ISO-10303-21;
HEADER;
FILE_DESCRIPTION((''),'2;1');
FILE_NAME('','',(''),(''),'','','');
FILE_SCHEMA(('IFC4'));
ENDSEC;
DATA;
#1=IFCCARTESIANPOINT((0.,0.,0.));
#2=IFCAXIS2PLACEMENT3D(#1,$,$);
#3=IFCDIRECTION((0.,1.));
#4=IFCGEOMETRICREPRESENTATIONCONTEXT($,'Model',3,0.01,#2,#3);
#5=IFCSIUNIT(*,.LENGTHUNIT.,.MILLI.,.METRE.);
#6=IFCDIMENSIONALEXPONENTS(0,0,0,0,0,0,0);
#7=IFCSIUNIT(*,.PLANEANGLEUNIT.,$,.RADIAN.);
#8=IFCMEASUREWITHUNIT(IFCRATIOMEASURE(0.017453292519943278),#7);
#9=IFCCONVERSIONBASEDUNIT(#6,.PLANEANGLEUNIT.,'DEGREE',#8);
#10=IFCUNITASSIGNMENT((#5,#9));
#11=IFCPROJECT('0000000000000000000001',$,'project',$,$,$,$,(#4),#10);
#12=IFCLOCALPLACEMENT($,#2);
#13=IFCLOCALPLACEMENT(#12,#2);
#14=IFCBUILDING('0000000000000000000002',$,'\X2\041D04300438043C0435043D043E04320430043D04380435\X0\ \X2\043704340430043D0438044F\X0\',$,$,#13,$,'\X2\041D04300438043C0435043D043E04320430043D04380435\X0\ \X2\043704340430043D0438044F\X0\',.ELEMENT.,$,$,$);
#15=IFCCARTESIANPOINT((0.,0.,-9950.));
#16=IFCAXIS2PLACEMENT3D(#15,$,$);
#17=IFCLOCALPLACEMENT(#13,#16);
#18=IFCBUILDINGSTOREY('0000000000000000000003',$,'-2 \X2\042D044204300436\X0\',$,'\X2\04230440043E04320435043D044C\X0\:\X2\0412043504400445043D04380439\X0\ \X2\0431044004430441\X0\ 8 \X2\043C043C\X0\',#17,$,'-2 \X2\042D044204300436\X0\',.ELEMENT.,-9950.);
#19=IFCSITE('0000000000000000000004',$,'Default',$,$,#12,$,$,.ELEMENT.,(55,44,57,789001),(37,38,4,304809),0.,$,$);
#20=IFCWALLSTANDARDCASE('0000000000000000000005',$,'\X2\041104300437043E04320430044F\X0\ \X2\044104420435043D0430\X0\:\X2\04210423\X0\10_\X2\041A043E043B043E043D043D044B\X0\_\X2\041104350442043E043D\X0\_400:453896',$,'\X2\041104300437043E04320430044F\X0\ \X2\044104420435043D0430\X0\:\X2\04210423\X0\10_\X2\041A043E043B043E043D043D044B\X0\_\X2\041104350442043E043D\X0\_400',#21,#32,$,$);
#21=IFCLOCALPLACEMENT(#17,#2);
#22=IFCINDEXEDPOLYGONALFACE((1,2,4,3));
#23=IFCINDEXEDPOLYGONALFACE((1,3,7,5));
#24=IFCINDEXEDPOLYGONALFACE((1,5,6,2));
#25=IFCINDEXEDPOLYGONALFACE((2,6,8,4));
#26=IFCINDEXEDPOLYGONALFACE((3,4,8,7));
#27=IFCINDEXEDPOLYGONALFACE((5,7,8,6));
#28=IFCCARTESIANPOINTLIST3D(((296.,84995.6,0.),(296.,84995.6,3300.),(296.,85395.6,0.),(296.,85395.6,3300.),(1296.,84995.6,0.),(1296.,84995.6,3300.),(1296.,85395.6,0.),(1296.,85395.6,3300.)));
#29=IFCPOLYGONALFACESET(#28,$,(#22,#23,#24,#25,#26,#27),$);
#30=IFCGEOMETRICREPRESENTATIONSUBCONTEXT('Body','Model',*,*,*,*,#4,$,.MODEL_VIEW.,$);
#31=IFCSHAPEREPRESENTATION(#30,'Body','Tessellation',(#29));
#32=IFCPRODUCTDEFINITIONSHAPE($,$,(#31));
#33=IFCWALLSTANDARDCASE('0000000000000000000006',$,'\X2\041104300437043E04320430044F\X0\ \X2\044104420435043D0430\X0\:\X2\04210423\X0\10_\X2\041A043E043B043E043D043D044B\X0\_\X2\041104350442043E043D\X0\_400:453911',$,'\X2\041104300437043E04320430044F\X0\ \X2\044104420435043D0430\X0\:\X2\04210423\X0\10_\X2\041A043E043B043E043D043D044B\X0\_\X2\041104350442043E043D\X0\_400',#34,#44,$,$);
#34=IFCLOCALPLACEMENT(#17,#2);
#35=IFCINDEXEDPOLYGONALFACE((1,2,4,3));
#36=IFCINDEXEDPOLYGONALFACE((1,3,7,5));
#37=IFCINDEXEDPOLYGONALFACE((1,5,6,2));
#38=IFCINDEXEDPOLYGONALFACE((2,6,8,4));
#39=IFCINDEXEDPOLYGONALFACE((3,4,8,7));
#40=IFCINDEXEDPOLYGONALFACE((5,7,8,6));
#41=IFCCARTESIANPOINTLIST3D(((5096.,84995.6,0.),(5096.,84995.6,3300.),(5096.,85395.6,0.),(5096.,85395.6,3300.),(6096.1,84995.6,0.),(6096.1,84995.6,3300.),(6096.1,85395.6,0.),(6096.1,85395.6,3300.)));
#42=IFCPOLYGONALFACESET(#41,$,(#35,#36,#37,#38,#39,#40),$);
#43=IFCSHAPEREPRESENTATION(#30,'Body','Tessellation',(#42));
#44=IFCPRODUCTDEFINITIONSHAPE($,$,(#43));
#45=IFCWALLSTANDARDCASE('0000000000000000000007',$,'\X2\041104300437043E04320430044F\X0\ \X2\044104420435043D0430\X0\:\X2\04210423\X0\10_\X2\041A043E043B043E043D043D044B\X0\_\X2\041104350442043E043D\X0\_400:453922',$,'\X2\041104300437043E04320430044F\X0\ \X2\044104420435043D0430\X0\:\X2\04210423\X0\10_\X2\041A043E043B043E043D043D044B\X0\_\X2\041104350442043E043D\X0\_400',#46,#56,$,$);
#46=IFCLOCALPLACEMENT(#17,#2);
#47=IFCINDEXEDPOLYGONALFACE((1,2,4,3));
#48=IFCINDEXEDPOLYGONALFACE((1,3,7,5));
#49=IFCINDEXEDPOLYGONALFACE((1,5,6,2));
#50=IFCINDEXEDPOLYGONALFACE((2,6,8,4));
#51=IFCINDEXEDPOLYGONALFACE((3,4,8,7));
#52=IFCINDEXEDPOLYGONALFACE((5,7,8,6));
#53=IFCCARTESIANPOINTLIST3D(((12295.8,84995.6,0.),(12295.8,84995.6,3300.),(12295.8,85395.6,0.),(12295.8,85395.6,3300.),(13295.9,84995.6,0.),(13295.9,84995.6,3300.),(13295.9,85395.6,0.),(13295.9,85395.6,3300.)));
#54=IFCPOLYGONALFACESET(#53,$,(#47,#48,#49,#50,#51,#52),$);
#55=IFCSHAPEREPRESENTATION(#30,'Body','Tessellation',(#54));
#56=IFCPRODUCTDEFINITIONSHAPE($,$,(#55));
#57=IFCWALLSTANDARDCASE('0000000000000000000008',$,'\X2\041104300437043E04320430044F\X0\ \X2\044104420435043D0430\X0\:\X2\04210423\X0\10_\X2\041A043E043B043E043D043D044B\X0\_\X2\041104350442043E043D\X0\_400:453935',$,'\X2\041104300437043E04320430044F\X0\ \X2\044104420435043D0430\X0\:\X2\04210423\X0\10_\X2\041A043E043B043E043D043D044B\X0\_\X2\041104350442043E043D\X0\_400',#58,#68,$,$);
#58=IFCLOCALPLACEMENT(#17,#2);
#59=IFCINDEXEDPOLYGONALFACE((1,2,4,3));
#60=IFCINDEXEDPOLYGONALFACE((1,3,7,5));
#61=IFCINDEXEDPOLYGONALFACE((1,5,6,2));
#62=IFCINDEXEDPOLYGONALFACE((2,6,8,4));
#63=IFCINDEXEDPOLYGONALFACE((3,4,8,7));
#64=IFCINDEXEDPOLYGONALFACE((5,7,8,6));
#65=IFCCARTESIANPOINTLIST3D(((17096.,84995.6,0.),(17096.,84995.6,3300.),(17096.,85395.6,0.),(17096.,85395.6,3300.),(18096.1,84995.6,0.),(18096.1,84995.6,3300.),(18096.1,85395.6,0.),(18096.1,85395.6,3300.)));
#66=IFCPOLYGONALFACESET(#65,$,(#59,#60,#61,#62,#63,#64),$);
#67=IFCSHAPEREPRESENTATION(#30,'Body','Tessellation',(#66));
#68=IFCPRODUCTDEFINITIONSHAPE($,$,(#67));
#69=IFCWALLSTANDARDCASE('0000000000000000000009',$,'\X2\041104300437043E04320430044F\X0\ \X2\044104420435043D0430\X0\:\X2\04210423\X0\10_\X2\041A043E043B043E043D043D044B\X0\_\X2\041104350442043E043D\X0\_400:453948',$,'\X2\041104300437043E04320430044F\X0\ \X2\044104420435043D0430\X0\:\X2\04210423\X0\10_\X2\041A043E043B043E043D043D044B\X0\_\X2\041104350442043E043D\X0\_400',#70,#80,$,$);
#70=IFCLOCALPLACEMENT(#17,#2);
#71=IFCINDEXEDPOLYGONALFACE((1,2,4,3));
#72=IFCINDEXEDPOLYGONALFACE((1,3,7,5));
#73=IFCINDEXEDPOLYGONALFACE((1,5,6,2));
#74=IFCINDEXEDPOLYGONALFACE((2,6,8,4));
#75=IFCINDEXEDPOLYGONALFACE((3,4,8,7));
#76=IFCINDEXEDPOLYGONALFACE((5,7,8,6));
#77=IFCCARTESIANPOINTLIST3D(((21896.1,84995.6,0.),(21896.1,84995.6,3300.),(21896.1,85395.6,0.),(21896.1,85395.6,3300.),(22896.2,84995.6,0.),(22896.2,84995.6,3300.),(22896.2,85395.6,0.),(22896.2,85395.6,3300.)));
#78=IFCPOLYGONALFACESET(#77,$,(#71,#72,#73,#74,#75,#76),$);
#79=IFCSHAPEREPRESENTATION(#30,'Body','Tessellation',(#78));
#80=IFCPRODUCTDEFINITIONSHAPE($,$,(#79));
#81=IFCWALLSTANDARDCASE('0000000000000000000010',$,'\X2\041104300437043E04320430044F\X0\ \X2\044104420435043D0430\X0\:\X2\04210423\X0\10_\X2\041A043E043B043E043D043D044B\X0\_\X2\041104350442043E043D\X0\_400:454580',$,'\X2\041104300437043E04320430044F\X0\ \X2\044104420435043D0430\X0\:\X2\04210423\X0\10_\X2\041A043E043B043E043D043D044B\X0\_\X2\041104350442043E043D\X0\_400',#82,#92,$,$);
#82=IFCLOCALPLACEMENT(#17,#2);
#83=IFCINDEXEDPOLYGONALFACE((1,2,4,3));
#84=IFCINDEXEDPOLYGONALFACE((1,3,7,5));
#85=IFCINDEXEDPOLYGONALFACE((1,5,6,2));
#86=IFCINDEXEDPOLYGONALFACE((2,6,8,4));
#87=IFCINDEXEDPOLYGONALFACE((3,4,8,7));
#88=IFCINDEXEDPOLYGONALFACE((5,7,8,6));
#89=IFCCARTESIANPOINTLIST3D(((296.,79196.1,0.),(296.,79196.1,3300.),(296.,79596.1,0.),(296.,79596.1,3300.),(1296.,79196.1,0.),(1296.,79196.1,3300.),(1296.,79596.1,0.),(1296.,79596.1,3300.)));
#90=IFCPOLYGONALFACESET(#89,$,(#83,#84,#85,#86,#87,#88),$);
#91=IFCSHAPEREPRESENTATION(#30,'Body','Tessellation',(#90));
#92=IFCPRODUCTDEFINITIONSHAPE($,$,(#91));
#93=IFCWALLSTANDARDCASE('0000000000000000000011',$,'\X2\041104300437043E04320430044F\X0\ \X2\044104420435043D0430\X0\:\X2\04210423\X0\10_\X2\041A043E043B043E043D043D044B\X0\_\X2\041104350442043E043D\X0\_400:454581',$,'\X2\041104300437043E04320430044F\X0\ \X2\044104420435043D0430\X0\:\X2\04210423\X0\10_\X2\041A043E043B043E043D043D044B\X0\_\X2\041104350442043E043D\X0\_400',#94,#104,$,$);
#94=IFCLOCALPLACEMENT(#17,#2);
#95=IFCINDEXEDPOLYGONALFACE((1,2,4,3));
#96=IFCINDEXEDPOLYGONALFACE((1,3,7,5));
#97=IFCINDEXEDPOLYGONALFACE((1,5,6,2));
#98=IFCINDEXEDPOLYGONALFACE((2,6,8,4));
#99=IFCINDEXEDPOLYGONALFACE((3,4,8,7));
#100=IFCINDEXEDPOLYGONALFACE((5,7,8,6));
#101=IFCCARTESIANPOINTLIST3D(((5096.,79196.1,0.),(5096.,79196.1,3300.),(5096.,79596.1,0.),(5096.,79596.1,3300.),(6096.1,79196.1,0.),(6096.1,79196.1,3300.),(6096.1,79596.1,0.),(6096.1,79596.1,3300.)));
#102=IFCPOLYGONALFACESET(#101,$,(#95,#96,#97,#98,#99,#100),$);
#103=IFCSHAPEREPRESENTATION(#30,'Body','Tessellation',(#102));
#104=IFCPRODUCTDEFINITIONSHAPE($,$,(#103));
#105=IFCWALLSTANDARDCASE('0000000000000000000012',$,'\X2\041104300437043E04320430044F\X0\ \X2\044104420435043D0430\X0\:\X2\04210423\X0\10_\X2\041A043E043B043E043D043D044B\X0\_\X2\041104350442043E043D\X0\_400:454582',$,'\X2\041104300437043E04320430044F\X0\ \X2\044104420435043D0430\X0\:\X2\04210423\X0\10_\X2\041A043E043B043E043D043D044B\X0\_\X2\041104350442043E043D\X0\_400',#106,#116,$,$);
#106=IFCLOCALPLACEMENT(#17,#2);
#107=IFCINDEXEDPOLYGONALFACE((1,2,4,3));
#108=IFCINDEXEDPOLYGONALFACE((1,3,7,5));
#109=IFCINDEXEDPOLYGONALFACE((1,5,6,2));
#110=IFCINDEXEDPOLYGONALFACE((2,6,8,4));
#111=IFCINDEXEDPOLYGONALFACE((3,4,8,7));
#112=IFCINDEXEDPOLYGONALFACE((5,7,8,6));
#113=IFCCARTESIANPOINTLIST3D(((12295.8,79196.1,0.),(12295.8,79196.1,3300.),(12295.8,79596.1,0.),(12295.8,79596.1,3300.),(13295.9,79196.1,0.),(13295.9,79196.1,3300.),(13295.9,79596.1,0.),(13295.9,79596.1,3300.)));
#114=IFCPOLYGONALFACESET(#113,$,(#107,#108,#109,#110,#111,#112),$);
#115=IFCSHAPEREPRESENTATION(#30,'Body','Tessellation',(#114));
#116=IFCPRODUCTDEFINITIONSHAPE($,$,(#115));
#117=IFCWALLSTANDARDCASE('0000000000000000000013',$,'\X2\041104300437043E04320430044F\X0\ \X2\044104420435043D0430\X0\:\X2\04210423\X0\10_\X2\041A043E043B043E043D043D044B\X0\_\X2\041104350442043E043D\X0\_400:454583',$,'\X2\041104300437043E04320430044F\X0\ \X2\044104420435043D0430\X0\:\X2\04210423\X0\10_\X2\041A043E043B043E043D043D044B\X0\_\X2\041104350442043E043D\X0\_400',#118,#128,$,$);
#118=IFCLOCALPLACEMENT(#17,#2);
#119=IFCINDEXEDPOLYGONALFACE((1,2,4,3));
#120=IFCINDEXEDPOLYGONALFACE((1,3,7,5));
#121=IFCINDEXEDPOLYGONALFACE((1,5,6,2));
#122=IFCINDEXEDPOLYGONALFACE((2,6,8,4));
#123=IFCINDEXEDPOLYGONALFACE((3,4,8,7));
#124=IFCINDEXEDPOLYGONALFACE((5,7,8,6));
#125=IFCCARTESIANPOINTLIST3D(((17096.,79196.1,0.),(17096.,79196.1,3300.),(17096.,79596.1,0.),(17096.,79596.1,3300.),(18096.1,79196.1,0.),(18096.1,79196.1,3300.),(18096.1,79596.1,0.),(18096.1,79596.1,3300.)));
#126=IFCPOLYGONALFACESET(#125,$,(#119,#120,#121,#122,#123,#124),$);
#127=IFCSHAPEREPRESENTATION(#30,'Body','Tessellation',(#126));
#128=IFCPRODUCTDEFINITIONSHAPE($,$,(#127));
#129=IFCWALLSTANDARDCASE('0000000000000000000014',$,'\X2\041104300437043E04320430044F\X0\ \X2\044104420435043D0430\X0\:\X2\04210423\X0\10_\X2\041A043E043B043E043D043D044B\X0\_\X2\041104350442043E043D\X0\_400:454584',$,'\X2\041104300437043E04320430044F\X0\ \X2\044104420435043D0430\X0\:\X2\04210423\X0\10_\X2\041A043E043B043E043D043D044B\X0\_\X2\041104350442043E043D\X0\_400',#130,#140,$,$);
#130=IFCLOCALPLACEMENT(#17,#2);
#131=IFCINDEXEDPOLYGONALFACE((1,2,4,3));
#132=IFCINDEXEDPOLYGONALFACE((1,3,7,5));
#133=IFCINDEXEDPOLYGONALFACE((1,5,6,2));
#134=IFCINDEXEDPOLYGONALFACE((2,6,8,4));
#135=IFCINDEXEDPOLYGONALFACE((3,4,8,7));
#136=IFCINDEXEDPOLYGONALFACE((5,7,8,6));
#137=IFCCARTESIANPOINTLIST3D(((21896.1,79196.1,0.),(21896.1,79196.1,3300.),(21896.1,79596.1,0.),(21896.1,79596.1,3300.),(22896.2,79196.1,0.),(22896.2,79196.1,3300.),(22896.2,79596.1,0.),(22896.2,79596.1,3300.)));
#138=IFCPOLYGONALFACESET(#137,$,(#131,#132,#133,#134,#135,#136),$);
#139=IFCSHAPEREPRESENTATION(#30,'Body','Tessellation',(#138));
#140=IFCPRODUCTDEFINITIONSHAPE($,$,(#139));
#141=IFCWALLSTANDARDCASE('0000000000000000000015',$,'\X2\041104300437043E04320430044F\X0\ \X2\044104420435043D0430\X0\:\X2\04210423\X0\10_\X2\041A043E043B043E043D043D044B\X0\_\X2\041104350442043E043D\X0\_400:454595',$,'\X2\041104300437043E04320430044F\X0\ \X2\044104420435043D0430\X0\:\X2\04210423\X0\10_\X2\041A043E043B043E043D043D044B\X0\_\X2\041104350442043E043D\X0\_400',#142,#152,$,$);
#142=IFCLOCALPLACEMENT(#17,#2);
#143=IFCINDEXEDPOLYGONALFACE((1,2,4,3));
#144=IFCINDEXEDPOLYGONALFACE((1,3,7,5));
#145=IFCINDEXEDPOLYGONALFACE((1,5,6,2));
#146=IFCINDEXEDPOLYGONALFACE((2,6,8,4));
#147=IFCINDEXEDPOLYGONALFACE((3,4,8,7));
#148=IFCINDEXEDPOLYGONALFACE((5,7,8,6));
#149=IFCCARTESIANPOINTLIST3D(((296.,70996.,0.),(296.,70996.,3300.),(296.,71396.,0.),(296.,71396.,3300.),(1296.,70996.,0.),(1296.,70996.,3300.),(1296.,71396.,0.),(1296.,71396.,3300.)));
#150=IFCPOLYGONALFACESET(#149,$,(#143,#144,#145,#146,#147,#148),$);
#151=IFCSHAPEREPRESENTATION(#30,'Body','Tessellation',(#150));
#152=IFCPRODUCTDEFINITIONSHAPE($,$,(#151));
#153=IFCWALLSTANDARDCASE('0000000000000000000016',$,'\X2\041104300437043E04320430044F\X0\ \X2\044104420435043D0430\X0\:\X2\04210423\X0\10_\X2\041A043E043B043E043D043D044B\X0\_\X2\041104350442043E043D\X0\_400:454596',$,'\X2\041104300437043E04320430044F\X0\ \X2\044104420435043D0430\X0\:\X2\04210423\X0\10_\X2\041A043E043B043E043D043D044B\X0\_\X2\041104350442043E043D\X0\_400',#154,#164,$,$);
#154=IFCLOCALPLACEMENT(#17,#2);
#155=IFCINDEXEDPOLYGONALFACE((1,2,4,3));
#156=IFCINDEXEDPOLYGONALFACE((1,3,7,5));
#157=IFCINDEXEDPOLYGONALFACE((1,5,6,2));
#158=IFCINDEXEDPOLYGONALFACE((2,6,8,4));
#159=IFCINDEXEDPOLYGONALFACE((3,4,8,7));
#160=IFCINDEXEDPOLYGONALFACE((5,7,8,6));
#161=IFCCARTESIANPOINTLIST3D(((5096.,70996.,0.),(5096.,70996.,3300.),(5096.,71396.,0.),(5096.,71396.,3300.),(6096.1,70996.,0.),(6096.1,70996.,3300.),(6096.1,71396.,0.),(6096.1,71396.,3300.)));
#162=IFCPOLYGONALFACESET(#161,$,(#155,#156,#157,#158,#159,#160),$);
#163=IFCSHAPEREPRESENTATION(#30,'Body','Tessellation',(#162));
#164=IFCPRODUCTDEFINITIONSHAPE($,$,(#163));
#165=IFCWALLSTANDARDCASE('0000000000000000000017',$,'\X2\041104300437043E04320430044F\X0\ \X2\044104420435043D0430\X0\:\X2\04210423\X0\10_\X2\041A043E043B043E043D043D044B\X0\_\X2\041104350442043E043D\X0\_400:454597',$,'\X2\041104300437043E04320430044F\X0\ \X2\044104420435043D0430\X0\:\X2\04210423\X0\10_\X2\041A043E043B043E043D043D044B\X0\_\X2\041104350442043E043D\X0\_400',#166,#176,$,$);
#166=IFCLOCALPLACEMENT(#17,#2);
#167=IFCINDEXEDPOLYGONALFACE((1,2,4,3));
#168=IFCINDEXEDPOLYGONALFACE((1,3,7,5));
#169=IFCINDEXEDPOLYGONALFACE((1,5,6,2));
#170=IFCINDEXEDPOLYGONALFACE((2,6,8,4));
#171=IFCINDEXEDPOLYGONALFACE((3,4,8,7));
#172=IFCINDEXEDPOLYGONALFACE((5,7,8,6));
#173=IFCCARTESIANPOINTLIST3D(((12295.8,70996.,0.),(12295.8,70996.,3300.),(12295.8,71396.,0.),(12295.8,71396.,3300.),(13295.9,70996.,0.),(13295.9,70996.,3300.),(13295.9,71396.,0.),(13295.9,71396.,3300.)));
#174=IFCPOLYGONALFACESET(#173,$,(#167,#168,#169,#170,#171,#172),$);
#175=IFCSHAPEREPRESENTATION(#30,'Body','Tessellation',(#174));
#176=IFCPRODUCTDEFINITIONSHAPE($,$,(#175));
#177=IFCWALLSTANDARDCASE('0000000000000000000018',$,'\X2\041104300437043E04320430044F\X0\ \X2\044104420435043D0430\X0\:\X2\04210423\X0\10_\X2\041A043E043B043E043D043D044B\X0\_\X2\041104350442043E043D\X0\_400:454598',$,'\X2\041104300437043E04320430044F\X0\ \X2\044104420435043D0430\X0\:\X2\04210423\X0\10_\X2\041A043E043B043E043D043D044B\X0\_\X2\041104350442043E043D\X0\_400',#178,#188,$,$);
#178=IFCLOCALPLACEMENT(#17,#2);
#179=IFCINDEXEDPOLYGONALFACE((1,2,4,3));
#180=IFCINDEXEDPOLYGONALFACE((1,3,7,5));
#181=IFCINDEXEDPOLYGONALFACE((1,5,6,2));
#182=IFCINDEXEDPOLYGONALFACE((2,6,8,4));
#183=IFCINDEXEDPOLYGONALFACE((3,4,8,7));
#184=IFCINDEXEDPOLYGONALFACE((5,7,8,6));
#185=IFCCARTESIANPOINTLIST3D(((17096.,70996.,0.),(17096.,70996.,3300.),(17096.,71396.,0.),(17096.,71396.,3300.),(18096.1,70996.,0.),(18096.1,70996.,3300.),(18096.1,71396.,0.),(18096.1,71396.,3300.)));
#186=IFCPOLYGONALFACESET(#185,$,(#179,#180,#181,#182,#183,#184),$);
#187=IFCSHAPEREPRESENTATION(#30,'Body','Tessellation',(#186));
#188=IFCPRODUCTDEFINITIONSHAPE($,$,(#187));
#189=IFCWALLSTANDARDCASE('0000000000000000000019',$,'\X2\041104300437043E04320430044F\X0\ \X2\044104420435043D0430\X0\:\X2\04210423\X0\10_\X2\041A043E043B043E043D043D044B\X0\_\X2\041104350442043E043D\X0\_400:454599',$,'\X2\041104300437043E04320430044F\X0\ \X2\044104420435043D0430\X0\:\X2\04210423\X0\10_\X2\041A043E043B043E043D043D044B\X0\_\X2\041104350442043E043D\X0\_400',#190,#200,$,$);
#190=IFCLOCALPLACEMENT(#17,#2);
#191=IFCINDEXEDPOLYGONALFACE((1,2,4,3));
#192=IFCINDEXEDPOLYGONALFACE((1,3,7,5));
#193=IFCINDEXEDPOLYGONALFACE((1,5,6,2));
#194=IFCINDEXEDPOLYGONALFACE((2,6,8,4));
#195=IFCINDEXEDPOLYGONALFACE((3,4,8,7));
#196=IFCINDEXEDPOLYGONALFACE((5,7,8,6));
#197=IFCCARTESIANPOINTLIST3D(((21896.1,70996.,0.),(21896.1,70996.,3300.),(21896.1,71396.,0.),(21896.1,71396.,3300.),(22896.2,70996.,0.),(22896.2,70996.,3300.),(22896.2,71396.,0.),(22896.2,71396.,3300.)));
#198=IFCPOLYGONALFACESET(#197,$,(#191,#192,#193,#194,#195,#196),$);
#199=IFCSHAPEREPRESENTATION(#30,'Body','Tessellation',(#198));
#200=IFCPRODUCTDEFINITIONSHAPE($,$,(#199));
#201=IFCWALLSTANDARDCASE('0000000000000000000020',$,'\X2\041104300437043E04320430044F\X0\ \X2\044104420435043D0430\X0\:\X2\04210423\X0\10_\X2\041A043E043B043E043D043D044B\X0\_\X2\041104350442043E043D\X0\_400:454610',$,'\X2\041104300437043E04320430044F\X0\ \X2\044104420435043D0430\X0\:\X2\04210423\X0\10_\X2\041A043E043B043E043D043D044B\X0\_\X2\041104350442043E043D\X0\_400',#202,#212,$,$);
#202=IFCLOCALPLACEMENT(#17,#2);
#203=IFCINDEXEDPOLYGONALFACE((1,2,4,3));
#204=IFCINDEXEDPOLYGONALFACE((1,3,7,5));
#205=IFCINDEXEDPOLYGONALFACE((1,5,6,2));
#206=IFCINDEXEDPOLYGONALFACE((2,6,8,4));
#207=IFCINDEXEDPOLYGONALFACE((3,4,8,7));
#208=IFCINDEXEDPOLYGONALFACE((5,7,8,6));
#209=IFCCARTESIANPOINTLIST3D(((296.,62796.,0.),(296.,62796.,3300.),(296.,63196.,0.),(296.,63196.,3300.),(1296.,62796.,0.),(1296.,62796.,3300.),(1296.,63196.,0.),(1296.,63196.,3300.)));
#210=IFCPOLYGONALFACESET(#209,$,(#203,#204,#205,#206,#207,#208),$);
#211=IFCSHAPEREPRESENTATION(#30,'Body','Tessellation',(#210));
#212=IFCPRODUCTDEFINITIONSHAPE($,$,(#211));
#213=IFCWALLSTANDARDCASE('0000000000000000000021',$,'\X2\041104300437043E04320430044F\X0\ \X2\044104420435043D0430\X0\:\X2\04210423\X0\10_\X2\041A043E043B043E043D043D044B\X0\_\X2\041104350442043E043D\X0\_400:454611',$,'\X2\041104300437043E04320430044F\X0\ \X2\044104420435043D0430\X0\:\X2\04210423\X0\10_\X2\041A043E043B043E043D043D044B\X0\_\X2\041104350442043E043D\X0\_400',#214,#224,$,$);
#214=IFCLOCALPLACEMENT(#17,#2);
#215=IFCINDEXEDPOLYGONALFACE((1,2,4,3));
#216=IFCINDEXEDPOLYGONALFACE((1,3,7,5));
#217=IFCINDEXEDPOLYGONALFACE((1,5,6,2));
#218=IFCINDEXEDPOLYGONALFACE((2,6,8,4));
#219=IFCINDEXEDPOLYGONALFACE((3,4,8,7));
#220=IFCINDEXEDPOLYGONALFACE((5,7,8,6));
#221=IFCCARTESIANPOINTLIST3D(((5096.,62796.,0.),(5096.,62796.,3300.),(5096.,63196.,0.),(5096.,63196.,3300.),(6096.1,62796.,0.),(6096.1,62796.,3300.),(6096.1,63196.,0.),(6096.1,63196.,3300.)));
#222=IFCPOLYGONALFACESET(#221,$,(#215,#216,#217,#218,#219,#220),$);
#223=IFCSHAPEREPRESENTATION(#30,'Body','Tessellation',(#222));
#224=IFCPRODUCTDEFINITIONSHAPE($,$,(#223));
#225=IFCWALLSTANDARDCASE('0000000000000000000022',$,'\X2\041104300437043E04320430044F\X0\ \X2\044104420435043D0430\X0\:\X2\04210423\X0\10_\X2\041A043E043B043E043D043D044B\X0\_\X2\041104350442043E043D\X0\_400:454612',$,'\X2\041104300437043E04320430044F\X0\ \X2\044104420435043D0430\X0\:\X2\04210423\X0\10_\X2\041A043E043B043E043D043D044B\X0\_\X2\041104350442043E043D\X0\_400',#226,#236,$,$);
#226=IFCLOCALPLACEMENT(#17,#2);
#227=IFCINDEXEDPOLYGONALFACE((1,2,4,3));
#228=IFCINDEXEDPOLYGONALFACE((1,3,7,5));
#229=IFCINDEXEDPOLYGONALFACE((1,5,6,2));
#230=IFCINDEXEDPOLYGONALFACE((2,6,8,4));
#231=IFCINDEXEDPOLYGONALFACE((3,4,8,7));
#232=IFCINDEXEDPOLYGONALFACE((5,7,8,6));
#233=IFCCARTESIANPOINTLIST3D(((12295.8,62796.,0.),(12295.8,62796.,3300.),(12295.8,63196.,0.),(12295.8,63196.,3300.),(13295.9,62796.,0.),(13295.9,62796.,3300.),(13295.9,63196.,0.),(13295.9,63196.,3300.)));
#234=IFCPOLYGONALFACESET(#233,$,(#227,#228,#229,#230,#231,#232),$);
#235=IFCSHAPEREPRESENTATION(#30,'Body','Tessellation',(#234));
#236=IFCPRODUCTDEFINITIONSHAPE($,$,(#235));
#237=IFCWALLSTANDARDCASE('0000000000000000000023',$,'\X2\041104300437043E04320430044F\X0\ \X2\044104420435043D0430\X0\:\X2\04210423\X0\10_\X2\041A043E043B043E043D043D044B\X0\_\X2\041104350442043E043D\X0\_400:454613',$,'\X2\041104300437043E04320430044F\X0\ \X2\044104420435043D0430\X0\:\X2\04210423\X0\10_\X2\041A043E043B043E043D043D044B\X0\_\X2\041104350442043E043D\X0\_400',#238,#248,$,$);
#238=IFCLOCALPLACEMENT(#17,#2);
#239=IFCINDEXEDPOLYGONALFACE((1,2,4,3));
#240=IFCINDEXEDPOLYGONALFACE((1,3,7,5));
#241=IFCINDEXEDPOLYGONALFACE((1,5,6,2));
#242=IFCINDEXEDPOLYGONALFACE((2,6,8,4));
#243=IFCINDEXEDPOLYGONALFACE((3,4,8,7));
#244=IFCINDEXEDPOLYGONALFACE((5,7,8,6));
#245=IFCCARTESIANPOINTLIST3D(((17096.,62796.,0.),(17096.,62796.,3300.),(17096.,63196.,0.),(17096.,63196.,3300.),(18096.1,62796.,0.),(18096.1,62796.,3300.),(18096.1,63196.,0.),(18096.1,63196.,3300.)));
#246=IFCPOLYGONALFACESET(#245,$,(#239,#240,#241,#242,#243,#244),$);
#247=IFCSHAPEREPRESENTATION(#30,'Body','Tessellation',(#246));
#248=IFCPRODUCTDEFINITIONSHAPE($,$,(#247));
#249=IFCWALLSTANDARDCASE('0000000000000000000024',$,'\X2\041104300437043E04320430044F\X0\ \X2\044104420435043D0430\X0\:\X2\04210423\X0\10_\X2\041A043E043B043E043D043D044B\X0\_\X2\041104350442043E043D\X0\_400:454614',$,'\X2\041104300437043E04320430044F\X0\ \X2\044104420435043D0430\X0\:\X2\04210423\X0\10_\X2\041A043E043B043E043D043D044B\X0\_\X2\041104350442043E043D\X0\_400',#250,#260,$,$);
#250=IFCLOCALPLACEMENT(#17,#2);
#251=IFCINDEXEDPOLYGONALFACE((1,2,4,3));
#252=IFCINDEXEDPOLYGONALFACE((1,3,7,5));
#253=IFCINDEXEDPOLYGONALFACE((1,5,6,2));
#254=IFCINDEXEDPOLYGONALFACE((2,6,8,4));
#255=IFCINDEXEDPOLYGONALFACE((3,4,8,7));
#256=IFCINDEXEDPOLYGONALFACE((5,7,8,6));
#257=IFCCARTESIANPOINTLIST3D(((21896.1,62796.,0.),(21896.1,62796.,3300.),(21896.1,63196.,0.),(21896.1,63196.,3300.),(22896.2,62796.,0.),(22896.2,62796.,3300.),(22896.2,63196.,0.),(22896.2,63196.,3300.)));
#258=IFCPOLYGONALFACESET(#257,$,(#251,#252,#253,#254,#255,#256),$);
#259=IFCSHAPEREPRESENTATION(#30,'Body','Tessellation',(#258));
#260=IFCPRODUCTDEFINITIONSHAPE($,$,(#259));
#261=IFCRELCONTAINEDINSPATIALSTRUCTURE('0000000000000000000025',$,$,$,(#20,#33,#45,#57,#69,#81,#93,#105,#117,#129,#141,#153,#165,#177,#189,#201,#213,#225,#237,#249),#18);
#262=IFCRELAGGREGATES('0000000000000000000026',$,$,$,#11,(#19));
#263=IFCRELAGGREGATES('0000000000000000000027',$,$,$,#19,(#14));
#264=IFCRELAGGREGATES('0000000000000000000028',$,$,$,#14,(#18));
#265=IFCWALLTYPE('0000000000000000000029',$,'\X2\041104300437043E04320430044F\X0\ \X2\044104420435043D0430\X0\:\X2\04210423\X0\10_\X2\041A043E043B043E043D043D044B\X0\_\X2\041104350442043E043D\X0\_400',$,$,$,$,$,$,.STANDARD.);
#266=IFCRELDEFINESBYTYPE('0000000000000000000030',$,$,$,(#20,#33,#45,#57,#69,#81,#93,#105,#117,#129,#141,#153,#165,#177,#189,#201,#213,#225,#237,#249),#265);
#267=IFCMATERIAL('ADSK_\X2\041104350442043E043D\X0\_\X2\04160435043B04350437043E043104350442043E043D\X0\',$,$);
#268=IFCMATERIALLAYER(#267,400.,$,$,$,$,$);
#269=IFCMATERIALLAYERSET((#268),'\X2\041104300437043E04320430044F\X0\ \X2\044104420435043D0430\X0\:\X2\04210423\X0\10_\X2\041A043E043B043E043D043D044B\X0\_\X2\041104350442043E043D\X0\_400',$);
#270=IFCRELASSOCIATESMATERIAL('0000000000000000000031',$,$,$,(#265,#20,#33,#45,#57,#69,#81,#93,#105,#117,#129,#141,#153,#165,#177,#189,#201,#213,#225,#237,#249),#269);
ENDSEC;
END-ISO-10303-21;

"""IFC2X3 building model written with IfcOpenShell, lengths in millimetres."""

from ifc_helpers import new_model, entity, si_unit, converted_unit, direction, frame, frame_2d, origin, place, context, subcontext, project, spatial, rectangle, extrude, material, layer, layer_set, layer_usage, type_object, element, save


model = new_model("IFC2X3")

# Units and contexts
model_context = context("Model", 3, precision=0.01, world=origin(), true_north=direction((0.0, 1.0)))
body_context = subcontext(model_context, "Body", "Model", "MODEL_VIEW")
ifc_project = project(units=[si_unit("LENGTHUNIT", "METRE", prefix="MILLI"), converted_unit("PLANEANGLEUNIT", "DEGREE", entity("IfcRatioMeasure", 0.017453292519943278), si_unit("PLANEANGLEUNIT", "RADIAN"), dimensions=[0, 0, 0, 0, 0, 0, 0])], contexts=[model_context])

# Site, building, storey
site_placement = place(None, origin())
site = spatial("IfcSite", under=ifc_project, at=site_placement, Name="Default", CompositionType="ELEMENT", RefLatitude=(55, 44, 57, 789001), RefLongitude=(37, 38, 4, 304809), RefElevation=0.0)
building_placement = place(site_placement, origin())
building = spatial("IfcBuilding", under=site, at=building_placement, Name="Наименование здания", LongName="Наименование здания", CompositionType="ELEMENT")
storey_placement = place(building_placement, frame((0.0, 0.0, -9950.0)))
storey = spatial("IfcBuildingStorey", under=building, at=storey_placement, Name="-2 Этаж", ObjectType="Уровень:Верхний брус 8 мм", LongName="-2 Этаж", CompositionType="ELEMENT", Elevation=-9950.0)

# Walls
ifc_material = material(Name="ADSK_Бетон_Железобетон")
ifc_layer_1 = layer(ifc_material, 400.0)
ifc_layer_set_1 = layer_set([ifc_layer_1], Name="Базовая стена:СУ10_Колонны_Бетон_400")
ifc_layer_usage_1 = layer_usage(ifc_layer_set_1, "AXIS2", "NEGATIVE", 200.0)
wall_type_1 = type_object("IfcWallType", Name="Базовая стена:СУ10_Колонны_Бетон_400", PredefinedType="STANDARD", material=ifc_layer_set_1)
for number, where, name in (
    (1, (296.0, 85195.6, 0.0), "Базовая стена:СУ10_Колонны_Бетон_400:453896"),
    (2, (5096.0, 85195.6, 0.0), "Базовая стена:СУ10_Колонны_Бетон_400:453911"),
    (3, (12295.8, 85195.6, 0.0), "Базовая стена:СУ10_Колонны_Бетон_400:453922"),
    (4, (17096.0, 85195.6, 0.0), "Базовая стена:СУ10_Колонны_Бетон_400:453935"),
    (5, (21896.1, 85195.6, 0.0), "Базовая стена:СУ10_Колонны_Бетон_400:453948"),
    (6, (296.0, 79396.1, 0.0), "Базовая стена:СУ10_Колонны_Бетон_400:454580"),
    (7, (5096.0, 79396.1, 0.0), "Базовая стена:СУ10_Колонны_Бетон_400:454581"),
    (8, (12295.8, 79396.1, 0.0), "Базовая стена:СУ10_Колонны_Бетон_400:454582"),
    (9, (17096.0, 79396.1, 0.0), "Базовая стена:СУ10_Колонны_Бетон_400:454583"),
    (10, (21896.1, 79396.1, 0.0), "Базовая стена:СУ10_Колонны_Бетон_400:454584"),
):
    element("IfcWallStandardCase", number, at=place(storey_placement, frame(where)), inside=storey, type_object=wall_type_1, material=ifc_layer_usage_1, Name=name, ObjectType="Базовая стена:СУ10_Колонны_Бетон_400", context=body_context, shape_type="SweptSolid", body=[
        extrude(rectangle(XDim=1000.1, YDim=400.0, at=frame_2d((500.0, 0.0), x_axis=(-1.0, 0.0))), origin(), (0.0, 0.0, 1.0), 3300.0),
    ])
for number, where, name in (
    (11, (296.0, 71196.0, 0.0), "Базовая стена:СУ10_Колонны_Бетон_400:454595"),
    (12, (5096.0, 71196.0, 0.0), "Базовая стена:СУ10_Колонны_Бетон_400:454596"),
    (13, (12295.8, 71196.0, 0.0), "Базовая стена:СУ10_Колонны_Бетон_400:454597"),
    (14, (17096.0, 71196.0, 0.0), "Базовая стена:СУ10_Колонны_Бетон_400:454598"),
    (15, (21896.1, 71196.0, 0.0), "Базовая стена:СУ10_Колонны_Бетон_400:454599"),
    (16, (296.0, 62996.0, 0.0), "Базовая стена:СУ10_Колонны_Бетон_400:454610"),
    (17, (5096.0, 62996.0, 0.0), "Базовая стена:СУ10_Колонны_Бетон_400:454611"),
    (18, (12295.8, 62996.0, 0.0), "Базовая стена:СУ10_Колонны_Бетон_400:454612"),
    (19, (17096.0, 62996.0, 0.0), "Базовая стена:СУ10_Колонны_Бетон_400:454613"),
    (20, (21896.1, 62996.0, 0.0), "Базовая стена:СУ10_Колонны_Бетон_400:454614"),
):
    element("IfcWallStandardCase", number, at=place(storey_placement, frame(where)), inside=storey, type_object=wall_type_1, material=ifc_layer_usage_1, Name=name, ObjectType="Базовая стена:СУ10_Колонны_Бетон_400", context=body_context, shape_type="SweptSolid", body=[
        extrude(rectangle(XDim=1000.1, YDim=400.0, at=frame_2d((500.0, 0.0), x_axis=(-1.0, 0.0))), origin(), (0.0, 0.0, 1.0), 3300.0),
    ])

save(model, "model.ifc")
